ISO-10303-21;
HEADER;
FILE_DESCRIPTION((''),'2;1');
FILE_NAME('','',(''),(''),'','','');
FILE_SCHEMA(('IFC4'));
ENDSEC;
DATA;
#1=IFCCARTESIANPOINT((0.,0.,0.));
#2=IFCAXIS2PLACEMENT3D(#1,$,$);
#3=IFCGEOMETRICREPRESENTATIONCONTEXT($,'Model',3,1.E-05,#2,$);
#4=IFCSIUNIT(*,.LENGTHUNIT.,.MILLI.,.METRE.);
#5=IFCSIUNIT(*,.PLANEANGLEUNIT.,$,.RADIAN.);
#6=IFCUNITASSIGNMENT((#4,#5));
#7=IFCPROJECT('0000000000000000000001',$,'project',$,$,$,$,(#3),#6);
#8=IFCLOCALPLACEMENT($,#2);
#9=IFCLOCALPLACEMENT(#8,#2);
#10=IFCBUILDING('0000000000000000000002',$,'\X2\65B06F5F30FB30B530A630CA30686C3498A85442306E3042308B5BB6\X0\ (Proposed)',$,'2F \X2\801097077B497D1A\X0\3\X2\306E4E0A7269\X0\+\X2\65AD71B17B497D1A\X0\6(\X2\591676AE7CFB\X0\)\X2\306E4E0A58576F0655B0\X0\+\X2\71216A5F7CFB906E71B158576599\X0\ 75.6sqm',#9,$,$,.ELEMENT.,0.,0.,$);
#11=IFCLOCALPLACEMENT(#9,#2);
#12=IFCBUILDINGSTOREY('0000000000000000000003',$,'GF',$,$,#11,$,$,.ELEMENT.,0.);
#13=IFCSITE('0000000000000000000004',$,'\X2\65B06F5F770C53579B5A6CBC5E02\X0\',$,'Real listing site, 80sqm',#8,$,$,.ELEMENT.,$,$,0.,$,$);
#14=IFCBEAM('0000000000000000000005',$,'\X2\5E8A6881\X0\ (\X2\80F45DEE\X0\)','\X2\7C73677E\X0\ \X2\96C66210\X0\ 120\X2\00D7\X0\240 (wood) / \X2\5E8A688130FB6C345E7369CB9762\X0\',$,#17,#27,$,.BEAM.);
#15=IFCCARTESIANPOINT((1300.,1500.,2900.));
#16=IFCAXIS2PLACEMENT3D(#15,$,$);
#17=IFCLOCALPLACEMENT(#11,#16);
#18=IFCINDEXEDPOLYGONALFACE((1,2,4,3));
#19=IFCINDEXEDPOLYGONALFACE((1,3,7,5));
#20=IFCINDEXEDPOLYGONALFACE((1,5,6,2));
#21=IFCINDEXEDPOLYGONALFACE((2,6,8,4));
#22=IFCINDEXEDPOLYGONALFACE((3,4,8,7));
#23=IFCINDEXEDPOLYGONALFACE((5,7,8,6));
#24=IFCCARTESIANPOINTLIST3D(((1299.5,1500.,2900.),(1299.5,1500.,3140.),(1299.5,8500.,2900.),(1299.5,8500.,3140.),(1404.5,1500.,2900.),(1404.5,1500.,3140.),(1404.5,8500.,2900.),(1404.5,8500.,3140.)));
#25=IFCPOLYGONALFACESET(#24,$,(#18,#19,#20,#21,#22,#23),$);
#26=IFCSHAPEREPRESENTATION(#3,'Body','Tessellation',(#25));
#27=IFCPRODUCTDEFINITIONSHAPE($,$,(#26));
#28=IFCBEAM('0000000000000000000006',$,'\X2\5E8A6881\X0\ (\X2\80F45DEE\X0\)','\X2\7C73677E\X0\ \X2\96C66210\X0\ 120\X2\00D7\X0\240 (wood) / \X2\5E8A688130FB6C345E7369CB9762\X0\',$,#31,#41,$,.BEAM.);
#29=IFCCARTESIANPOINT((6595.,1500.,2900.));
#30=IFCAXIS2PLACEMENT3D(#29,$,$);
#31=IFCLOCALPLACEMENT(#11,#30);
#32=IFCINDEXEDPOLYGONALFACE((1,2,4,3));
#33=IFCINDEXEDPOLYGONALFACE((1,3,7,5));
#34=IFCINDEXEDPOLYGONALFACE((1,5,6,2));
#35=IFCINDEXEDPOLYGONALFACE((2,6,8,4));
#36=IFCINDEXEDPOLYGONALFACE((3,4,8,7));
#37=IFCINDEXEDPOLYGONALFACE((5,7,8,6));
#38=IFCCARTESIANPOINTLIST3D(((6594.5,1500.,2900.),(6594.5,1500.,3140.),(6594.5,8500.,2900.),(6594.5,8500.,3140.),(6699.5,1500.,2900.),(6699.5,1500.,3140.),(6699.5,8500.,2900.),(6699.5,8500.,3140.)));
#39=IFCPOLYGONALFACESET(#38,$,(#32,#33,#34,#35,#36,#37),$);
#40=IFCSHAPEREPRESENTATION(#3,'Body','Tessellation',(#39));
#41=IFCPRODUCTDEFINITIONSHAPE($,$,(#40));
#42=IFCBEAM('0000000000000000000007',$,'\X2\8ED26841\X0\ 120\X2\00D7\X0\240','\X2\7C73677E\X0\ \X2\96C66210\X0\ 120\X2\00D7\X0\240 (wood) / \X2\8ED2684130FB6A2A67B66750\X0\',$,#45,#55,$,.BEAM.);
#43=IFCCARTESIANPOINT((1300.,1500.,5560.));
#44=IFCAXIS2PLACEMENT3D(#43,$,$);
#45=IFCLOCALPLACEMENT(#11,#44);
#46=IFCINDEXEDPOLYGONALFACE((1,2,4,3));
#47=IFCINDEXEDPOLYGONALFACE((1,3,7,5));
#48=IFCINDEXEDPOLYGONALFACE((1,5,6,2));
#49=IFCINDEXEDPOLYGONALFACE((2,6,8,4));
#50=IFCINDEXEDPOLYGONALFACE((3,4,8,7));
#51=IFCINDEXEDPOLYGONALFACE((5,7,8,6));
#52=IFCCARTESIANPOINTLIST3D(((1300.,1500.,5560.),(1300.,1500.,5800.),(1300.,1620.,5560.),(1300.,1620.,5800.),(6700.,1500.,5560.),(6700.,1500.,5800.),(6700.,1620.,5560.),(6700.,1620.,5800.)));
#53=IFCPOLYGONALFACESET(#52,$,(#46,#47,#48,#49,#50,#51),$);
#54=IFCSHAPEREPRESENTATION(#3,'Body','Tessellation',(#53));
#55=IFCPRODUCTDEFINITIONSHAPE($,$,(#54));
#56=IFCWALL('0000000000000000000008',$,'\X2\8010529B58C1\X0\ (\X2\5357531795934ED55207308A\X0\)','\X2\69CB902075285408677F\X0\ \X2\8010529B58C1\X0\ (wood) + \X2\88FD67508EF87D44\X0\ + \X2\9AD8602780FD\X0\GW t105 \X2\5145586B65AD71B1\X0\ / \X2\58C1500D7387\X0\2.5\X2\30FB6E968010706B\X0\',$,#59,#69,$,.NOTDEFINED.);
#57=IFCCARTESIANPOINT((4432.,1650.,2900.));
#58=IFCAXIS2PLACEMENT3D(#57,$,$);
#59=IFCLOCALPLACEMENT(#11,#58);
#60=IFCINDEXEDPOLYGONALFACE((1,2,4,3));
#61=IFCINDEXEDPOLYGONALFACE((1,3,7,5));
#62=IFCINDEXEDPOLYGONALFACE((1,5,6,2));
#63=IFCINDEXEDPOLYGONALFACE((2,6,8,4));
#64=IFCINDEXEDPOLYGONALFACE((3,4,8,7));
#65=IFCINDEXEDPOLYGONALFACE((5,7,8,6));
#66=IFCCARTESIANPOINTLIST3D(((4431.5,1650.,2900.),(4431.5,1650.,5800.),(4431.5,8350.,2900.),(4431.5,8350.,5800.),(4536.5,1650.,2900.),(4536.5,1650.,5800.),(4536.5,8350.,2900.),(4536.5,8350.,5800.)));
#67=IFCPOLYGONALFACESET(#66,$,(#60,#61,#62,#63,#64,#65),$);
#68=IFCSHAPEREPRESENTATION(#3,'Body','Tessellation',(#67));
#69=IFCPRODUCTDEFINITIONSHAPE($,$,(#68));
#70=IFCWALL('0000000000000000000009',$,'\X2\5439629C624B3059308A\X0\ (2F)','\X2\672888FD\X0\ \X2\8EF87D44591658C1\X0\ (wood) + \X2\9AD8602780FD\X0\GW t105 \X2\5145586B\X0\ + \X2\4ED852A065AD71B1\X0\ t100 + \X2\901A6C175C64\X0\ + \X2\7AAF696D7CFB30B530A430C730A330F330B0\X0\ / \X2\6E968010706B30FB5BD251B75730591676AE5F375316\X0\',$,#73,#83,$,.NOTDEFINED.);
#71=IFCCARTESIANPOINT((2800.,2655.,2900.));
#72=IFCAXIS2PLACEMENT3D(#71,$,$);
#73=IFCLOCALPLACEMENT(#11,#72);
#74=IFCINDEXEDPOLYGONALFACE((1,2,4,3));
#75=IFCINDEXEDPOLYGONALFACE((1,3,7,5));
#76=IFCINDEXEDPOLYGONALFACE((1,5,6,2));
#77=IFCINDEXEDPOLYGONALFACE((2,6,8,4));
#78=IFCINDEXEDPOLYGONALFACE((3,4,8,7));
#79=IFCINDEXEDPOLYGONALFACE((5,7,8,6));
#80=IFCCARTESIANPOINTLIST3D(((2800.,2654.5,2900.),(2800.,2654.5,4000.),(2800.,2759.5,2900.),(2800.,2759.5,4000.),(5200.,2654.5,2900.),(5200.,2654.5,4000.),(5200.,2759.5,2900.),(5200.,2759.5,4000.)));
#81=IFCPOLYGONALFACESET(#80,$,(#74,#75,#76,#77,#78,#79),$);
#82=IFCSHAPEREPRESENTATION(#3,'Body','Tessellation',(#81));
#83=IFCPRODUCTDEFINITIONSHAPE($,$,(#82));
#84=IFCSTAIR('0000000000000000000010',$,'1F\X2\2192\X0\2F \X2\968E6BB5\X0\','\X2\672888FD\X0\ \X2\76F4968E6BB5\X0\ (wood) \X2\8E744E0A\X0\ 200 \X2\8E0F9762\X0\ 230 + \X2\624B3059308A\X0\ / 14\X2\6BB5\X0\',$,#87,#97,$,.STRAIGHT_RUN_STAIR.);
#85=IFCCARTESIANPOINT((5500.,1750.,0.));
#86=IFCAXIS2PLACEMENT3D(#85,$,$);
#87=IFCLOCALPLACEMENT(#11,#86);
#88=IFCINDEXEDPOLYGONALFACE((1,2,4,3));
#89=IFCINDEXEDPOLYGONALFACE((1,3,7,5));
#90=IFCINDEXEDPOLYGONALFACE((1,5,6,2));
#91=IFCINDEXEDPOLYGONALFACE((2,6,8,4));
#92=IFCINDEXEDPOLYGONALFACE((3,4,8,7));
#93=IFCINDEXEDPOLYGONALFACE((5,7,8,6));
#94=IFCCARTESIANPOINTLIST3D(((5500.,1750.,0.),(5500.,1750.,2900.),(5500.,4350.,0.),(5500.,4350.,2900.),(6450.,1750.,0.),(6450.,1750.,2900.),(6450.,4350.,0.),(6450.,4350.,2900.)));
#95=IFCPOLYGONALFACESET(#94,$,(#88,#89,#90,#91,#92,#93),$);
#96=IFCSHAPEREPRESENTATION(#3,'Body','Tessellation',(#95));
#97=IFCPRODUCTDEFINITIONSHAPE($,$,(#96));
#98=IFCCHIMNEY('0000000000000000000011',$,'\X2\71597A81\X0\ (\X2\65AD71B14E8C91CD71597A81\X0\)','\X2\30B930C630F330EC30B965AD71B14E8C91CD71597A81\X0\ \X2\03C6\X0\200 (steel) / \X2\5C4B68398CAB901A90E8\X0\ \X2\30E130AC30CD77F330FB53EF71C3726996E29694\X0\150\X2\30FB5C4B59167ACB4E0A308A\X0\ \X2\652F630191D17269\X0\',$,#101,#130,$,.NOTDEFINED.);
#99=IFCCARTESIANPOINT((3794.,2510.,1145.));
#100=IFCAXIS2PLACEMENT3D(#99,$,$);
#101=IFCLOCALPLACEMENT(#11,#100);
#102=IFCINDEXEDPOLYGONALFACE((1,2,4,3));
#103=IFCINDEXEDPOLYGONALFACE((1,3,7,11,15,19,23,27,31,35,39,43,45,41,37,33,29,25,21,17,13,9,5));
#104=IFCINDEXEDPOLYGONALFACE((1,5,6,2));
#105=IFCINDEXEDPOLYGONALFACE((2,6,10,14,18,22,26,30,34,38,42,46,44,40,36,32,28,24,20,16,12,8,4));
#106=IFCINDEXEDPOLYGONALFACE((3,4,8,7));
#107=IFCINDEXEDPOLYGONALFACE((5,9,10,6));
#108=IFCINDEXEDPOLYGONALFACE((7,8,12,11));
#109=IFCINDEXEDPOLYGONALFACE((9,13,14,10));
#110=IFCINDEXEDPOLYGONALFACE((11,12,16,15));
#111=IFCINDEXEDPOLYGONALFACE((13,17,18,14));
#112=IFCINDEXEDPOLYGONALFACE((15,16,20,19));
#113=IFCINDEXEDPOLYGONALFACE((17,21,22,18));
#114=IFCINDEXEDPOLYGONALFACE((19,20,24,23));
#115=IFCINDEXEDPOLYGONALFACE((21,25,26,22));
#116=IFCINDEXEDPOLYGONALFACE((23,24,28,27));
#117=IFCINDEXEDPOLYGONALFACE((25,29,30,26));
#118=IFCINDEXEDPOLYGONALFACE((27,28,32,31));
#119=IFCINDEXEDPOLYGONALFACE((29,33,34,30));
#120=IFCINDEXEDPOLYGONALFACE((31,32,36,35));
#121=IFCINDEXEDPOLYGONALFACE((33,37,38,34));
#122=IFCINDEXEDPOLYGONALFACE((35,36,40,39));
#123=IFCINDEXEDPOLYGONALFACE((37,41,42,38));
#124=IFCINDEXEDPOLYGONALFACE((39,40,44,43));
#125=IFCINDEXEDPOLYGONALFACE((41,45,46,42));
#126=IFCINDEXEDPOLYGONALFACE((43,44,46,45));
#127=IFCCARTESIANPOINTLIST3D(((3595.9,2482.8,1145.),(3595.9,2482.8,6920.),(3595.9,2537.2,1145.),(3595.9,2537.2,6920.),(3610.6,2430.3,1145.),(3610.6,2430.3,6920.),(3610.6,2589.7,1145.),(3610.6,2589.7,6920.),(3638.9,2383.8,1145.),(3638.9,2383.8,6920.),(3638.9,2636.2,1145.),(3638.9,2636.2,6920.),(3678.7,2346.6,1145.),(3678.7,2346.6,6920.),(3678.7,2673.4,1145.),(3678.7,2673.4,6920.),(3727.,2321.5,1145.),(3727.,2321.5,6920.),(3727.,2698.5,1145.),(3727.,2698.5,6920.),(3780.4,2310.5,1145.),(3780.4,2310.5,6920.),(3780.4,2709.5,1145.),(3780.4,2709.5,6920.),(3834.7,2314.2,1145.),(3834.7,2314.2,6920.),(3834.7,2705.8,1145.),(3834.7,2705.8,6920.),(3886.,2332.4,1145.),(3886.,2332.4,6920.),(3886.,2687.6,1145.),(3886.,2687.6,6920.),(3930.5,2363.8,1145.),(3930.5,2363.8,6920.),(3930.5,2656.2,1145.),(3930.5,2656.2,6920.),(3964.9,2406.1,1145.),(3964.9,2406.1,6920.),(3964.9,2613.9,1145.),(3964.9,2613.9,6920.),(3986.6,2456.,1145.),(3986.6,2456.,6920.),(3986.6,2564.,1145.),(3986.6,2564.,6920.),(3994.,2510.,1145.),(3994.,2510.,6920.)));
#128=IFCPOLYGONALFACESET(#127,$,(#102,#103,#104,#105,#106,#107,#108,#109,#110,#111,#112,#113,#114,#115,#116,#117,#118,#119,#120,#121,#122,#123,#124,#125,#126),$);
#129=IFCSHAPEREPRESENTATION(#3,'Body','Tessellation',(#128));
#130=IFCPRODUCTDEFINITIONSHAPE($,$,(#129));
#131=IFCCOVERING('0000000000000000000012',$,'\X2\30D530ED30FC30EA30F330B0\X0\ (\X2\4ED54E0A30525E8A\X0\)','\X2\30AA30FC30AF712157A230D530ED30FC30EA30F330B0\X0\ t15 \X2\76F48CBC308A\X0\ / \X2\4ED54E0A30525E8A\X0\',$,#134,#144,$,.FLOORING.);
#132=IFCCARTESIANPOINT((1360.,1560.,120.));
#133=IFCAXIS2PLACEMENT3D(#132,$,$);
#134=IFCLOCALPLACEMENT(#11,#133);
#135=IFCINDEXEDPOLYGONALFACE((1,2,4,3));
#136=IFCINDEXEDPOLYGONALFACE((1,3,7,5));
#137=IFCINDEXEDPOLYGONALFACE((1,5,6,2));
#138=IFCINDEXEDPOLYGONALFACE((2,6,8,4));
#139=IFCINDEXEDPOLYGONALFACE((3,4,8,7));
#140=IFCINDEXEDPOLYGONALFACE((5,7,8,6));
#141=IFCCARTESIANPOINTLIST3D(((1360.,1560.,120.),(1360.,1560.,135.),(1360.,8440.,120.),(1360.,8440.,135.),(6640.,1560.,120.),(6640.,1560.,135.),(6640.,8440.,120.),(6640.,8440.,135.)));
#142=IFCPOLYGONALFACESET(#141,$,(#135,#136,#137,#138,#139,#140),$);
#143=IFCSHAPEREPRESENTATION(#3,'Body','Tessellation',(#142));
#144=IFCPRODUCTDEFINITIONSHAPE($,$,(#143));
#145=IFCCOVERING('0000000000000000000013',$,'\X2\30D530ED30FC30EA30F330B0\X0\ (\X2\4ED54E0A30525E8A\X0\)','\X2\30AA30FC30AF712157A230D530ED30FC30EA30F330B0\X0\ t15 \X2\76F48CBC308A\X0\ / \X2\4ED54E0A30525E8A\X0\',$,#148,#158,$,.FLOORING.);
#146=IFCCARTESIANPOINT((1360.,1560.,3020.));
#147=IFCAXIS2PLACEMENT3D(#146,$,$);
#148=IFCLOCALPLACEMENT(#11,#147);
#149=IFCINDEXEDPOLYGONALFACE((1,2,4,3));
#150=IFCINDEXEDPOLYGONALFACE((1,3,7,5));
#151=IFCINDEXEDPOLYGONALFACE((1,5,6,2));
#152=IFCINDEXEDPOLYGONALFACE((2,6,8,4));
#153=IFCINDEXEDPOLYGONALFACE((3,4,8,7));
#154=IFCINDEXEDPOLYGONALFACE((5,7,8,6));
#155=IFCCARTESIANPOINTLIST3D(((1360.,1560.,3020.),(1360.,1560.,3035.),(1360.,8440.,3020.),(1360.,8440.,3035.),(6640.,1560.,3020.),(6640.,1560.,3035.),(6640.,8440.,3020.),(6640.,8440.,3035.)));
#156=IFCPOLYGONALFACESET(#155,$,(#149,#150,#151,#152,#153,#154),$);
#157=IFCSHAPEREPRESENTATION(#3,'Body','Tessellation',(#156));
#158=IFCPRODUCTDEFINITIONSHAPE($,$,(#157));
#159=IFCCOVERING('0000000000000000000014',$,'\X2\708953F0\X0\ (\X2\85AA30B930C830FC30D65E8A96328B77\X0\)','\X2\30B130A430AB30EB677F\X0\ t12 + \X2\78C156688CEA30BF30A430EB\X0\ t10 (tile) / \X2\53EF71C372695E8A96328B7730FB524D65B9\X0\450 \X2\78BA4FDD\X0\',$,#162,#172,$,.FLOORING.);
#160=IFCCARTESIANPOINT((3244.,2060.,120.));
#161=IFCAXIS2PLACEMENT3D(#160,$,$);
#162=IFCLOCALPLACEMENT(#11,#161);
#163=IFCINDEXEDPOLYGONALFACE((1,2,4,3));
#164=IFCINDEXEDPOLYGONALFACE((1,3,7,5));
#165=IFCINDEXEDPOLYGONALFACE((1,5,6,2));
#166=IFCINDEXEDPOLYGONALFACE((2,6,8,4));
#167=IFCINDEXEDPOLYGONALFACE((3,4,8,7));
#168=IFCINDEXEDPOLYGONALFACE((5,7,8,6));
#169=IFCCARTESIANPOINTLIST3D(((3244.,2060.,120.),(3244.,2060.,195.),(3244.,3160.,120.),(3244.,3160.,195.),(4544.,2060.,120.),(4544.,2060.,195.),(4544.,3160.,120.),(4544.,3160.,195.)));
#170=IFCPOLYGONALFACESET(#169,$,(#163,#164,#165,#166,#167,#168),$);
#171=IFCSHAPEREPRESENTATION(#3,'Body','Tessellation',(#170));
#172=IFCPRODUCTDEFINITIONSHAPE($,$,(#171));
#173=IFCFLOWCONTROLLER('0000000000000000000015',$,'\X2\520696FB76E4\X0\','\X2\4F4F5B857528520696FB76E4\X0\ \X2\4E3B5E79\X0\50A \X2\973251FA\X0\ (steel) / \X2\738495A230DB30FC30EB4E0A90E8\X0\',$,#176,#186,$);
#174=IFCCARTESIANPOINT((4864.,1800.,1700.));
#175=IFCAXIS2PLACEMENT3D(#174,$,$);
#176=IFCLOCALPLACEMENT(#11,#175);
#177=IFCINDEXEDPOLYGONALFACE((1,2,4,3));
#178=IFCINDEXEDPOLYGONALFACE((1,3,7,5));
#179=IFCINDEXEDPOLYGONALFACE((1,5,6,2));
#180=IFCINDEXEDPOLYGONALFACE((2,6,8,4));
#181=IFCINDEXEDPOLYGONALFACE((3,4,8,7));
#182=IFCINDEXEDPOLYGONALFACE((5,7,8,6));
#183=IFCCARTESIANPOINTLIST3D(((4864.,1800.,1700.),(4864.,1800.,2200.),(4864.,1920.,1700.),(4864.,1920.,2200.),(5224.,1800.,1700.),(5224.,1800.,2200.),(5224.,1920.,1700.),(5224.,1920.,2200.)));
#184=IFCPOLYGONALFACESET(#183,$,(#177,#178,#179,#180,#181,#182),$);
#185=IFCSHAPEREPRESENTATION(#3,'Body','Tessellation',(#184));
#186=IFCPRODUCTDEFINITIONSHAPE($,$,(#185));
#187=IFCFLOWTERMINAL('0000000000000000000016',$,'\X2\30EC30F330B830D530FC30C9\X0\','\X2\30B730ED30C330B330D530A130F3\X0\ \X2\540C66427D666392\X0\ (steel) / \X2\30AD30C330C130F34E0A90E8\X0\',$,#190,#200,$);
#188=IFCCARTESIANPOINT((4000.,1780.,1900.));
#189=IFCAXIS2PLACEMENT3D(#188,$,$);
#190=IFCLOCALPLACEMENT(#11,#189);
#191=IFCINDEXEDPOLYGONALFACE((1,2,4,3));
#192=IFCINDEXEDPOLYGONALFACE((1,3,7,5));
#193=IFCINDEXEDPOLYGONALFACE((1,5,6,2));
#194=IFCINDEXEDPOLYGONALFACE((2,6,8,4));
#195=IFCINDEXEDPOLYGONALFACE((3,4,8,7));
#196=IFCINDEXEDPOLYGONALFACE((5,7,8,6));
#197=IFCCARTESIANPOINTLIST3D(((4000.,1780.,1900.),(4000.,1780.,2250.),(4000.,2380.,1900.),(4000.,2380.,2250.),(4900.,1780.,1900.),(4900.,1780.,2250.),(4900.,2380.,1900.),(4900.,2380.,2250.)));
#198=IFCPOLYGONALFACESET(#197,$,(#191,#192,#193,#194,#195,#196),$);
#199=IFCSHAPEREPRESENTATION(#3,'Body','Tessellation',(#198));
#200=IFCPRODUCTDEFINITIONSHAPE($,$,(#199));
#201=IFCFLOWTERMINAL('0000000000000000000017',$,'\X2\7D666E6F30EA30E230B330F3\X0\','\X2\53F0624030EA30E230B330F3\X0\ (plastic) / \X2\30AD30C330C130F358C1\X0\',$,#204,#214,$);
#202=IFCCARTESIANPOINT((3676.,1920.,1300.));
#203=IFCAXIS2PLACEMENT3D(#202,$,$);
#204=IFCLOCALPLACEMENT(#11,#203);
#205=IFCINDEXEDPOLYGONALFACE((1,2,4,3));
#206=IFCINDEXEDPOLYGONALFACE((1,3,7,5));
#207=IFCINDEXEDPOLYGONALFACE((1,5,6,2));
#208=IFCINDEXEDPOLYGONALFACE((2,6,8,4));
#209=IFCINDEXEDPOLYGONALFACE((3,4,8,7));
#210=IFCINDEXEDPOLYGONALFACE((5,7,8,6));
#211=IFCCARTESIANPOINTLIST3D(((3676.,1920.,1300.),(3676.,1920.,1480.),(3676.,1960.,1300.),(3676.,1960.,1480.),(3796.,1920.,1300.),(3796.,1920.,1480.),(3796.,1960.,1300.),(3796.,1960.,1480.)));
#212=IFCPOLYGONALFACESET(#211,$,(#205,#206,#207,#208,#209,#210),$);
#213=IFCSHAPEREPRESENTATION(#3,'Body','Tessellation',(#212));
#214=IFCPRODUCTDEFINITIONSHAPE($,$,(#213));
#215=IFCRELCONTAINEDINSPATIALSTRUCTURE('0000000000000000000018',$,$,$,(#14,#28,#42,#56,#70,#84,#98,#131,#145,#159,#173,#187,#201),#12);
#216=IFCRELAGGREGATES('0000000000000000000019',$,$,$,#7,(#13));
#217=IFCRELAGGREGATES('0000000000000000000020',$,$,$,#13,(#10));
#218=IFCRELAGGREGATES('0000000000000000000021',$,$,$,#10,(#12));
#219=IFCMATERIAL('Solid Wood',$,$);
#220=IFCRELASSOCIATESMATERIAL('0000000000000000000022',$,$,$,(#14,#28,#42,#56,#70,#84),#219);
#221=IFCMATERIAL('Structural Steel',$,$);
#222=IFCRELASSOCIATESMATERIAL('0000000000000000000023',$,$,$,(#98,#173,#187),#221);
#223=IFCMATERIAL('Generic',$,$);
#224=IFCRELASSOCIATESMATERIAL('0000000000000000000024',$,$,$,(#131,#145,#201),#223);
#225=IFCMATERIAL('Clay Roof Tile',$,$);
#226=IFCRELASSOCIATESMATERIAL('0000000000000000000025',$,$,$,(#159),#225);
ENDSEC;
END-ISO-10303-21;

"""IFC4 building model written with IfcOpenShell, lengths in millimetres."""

from ifc_helpers import new_model, si_unit, frame, frame_2d, origin, origin_2d, place, context, project, spatial, rectangle, circle, extrude, material, element, save


model = new_model("IFC4")

# Units and contexts
model_context = context("Model", 3, precision=1e-05, world=origin())
ifc_project = project(units=[si_unit("LENGTHUNIT", "METRE", prefix="MILLI"), si_unit("PLANEANGLEUNIT", "RADIAN")], contexts=[model_context])

# Site, building, storey
site_placement = place(None, origin())
site = spatial("IfcSite", under=ifc_project, at=site_placement, Name="新潟県南魚沼市", ObjectType="Real listing site, 80sqm", CompositionType="ELEMENT", RefElevation=0.0)
building_placement = place(site_placement, origin())
building = spatial("IfcBuilding", under=site, at=building_placement, Name="新潟・サウナと水風呂のある家 (Proposed)", ObjectType="2F 耐震等級3の上物+断熱等級6(外皮系)の上塗漆喰+無機系遮熱塗料 75.6sqm", CompositionType="ELEMENT", ElevationOfRefHeight=0.0, ElevationOfTerrain=0.0)
storey_placement = place(building_placement, origin())
storey = spatial("IfcBuildingStorey", under=building, at=storey_placement, Name="GF", CompositionType="ELEMENT", Elevation=0.0)

# Beams
ifc_material_1 = material(Name="Solid Wood")
beam_1_placement = place(storey_placement, frame((1300.0, 1500.0, 2900.0)))
element("IfcBeam", 1, at=beam_1_placement, inside=storey, material=ifc_material_1, Name="床梁 (胴差)", Description="米松 集成 120×240 (wood) / 床梁・水平構面", PredefinedType="BEAM", context=model_context, shape_type="SweptSolid", body=[
    extrude(rectangle(XDim=105.0, YDim=7000.0, at=frame_2d((52.0, 3500.0))), frame((1300.0, 1500.0, 2900.0)), (0.0, 0.0, 1.0), 240.0),
])
beam_2_placement = place(storey_placement, frame((6595.0, 1500.0, 2900.0)))
element("IfcBeam", 2, at=beam_2_placement, inside=storey, material=ifc_material_1, Name="床梁 (胴差)", Description="米松 集成 120×240 (wood) / 床梁・水平構面", PredefinedType="BEAM", context=model_context, shape_type="SweptSolid", body=[
    extrude(rectangle(XDim=105.0, YDim=7000.0, at=frame_2d((52.0, 3500.0))), frame((6595.0, 1500.0, 2900.0)), (0.0, 0.0, 1.0), 240.0),
])
beam_3_placement = place(storey_placement, frame((1300.0, 1500.0, 5560.0)))
element("IfcBeam", 3, at=beam_3_placement, inside=storey, material=ifc_material_1, Name="軒桁 120×240", Description="米松 集成 120×240 (wood) / 軒桁・横架材", PredefinedType="BEAM", context=model_context, shape_type="SweptSolid", body=[
    extrude(rectangle(XDim=5400.0, YDim=120.0, at=frame_2d((2700.0, 60.0))), frame((1300.0, 1500.0, 5560.0)), (0.0, 0.0, 1.0), 240.0),
])

# Walls
wall_1_placement = place(storey_placement, frame((4432.0, 1650.0, 2900.0)))
element("IfcWall", 4, at=wall_1_placement, inside=storey, material=ifc_material_1, Name="耐力壁 (南北間仕切り)", Description="構造用合板 耐力壁 (wood) + 製材軸組 + 高性能GW t105 充填断熱 / 壁倍率2.5・準耐火", PredefinedType="NOTDEFINED", context=model_context, shape_type="SweptSolid", body=[
    extrude(rectangle(XDim=105.0, YDim=6700.0, at=frame_2d((52.0, 3350.0))), frame((4432.0, 1650.0, 2900.0)), (0.0, 0.0, 1.0), 2900.0),
])
wall_2_placement = place(storey_placement, frame((2800.0, 2655.0, 2900.0)))
element("IfcWall", 5, at=wall_2_placement, inside=storey, material=ifc_material_1, Name="吹抜手すり (2F)", Description="木製 軸組外壁 (wood) + 高性能GW t105 充填 + 付加断熱 t100 + 通気層 + 窯業系サイディング / 準耐火・寒冷地外皮強化", PredefinedType="NOTDEFINED", context=model_context, shape_type="SweptSolid", body=[
    extrude(rectangle(XDim=2400.0, YDim=105.0, at=frame_2d((1200.0, 52.0))), frame((2800.0, 2655.0, 2900.0)), (0.0, 0.0, 1.0), 1100.0),
])

# Stair
stair_placement = place(storey_placement, frame((5500.0, 1750.0, 0.0)))
element("IfcStair", 6, at=stair_placement, inside=storey, material=ifc_material_1, Name="1F→2F 階段", Description="木製 直階段 (wood) 蹴上 200 踏面 230 + 手すり / 14段", PredefinedType="STRAIGHT_RUN_STAIR", context=model_context, shape_type="SweptSolid", body=[
    extrude(rectangle(XDim=950.0, YDim=2600.0, at=frame_2d((475.0, 1300.0))), frame((5500.0, 1750.0, 0.0)), (0.0, 0.0, 1.0), 2900.0),
])

# Chimney
ifc_material_2 = material(Name="Structural Steel")
chimney_placement = place(storey_placement, frame((3794.0, 2510.0, 1145.0)))
element("IfcChimney", 7, at=chimney_placement, inside=storey, material=ifc_material_2, Name="煙突 (断熱二重煙突)", Description="ステンレス断熱二重煙突 φ200 (steel) / 屋根貫通部 メガネ石・可燃物離隔150・屋外立上り 支持金物", PredefinedType="NOTDEFINED", context=model_context, shape_type="SweptSolid", body=[
    extrude(circle(Radius=200.0, at=origin_2d()), frame((3794.0, 2510.0, 1145.0)), (0.0, 0.0, 1.0), 5775.0),
])

# Coverings
ifc_material_3 = material(Name="Generic")
covering_1_placement = place(storey_placement, frame((1360.0, 1560.0, 120.0)))
element("IfcCovering", 8, at=covering_1_placement, inside=storey, material=ifc_material_3, Name="フローリング (仕上げ床)", Description="オーク無垢フローリング t15 直貼り / 仕上げ床", PredefinedType="FLOORING", context=model_context, shape_type="SweptSolid", body=[
    extrude(rectangle(XDim=5280.0, YDim=6880.0, at=frame_2d((2640.0, 3440.0))), frame((1360.0, 1560.0, 120.0)), (0.0, 0.0, 1.0), 15.0),
])
covering_2_placement = place(storey_placement, frame((1360.0, 1560.0, 3020.0)))
element("IfcCovering", 9, at=covering_2_placement, inside=storey, material=ifc_material_3, Name="フローリング (仕上げ床)", Description="オーク無垢フローリング t15 直貼り / 仕上げ床", PredefinedType="FLOORING", context=model_context, shape_type="SweptSolid", body=[
    extrude(rectangle(XDim=5280.0, YDim=6880.0, at=frame_2d((2640.0, 3440.0))), frame((1360.0, 1560.0, 3020.0)), (0.0, 0.0, 1.0), 15.0),
])
ifc_material_4 = material(Name="Clay Roof Tile")
covering_3_placement = place(storey_placement, frame((3244.0, 2060.0, 120.0)))
element("IfcCovering", 10, at=covering_3_placement, inside=storey, material=ifc_material_4, Name="炉台 (薪ストーブ床防護)", Description="ケイカル板 t12 + 磁器質タイル t10 (tile) / 可燃物床防護・前方450 確保", PredefinedType="FLOORING", context=model_context, shape_type="SweptSolid", body=[
    extrude(rectangle(XDim=1300.0, YDim=1100.0, at=frame_2d((650.0, 550.0))), frame((3244.0, 2060.0, 120.0)), (0.0, 0.0, 1.0), 75.0),
])

# Flow controller
flow_controller_placement = place(storey_placement, frame((4864.0, 1800.0, 1700.0)))
element("IfcFlowController", 11, at=flow_controller_placement, inside=storey, material=ifc_material_2, Name="分電盤", Description="住宅用分電盤 主幹50A 露出 (steel) / 玄関ホール上部", context=model_context, shape_type="SweptSolid", body=[
    extrude(rectangle(XDim=360.0, YDim=120.0, at=frame_2d((180.0, 60.0))), frame((4864.0, 1800.0, 1700.0)), (0.0, 0.0, 1.0), 500.0),
])

# Flow terminals
flow_terminal_1_placement = place(storey_placement, frame((4000.0, 1780.0, 1900.0)))
element("IfcFlowTerminal", 12, at=flow_terminal_1_placement, inside=storey, material=ifc_material_2, Name="レンジフード", Description="シロッコファン 同時給排 (steel) / キッチン上部", context=model_context, shape_type="SweptSolid", body=[
    extrude(rectangle(XDim=900.0, YDim=600.0, at=frame_2d((450.0, 300.0))), frame((4000.0, 1780.0, 1900.0)), (0.0, 0.0, 1.0), 350.0),
])
flow_terminal_2_placement = place(storey_placement, frame((3676.0, 1920.0, 1300.0)))
element("IfcFlowTerminal", 13, at=flow_terminal_2_placement, inside=storey, material=ifc_material_3, Name="給湯リモコン", Description="台所リモコン (plastic) / キッチン壁", context=model_context, shape_type="SweptSolid", body=[
    extrude(rectangle(XDim=120.0, YDim=40.0, at=frame_2d((60.0, 20.0))), frame((3676.0, 1920.0, 1300.0)), (0.0, 0.0, 1.0), 180.0),
])

save(model, "model.ifc")
